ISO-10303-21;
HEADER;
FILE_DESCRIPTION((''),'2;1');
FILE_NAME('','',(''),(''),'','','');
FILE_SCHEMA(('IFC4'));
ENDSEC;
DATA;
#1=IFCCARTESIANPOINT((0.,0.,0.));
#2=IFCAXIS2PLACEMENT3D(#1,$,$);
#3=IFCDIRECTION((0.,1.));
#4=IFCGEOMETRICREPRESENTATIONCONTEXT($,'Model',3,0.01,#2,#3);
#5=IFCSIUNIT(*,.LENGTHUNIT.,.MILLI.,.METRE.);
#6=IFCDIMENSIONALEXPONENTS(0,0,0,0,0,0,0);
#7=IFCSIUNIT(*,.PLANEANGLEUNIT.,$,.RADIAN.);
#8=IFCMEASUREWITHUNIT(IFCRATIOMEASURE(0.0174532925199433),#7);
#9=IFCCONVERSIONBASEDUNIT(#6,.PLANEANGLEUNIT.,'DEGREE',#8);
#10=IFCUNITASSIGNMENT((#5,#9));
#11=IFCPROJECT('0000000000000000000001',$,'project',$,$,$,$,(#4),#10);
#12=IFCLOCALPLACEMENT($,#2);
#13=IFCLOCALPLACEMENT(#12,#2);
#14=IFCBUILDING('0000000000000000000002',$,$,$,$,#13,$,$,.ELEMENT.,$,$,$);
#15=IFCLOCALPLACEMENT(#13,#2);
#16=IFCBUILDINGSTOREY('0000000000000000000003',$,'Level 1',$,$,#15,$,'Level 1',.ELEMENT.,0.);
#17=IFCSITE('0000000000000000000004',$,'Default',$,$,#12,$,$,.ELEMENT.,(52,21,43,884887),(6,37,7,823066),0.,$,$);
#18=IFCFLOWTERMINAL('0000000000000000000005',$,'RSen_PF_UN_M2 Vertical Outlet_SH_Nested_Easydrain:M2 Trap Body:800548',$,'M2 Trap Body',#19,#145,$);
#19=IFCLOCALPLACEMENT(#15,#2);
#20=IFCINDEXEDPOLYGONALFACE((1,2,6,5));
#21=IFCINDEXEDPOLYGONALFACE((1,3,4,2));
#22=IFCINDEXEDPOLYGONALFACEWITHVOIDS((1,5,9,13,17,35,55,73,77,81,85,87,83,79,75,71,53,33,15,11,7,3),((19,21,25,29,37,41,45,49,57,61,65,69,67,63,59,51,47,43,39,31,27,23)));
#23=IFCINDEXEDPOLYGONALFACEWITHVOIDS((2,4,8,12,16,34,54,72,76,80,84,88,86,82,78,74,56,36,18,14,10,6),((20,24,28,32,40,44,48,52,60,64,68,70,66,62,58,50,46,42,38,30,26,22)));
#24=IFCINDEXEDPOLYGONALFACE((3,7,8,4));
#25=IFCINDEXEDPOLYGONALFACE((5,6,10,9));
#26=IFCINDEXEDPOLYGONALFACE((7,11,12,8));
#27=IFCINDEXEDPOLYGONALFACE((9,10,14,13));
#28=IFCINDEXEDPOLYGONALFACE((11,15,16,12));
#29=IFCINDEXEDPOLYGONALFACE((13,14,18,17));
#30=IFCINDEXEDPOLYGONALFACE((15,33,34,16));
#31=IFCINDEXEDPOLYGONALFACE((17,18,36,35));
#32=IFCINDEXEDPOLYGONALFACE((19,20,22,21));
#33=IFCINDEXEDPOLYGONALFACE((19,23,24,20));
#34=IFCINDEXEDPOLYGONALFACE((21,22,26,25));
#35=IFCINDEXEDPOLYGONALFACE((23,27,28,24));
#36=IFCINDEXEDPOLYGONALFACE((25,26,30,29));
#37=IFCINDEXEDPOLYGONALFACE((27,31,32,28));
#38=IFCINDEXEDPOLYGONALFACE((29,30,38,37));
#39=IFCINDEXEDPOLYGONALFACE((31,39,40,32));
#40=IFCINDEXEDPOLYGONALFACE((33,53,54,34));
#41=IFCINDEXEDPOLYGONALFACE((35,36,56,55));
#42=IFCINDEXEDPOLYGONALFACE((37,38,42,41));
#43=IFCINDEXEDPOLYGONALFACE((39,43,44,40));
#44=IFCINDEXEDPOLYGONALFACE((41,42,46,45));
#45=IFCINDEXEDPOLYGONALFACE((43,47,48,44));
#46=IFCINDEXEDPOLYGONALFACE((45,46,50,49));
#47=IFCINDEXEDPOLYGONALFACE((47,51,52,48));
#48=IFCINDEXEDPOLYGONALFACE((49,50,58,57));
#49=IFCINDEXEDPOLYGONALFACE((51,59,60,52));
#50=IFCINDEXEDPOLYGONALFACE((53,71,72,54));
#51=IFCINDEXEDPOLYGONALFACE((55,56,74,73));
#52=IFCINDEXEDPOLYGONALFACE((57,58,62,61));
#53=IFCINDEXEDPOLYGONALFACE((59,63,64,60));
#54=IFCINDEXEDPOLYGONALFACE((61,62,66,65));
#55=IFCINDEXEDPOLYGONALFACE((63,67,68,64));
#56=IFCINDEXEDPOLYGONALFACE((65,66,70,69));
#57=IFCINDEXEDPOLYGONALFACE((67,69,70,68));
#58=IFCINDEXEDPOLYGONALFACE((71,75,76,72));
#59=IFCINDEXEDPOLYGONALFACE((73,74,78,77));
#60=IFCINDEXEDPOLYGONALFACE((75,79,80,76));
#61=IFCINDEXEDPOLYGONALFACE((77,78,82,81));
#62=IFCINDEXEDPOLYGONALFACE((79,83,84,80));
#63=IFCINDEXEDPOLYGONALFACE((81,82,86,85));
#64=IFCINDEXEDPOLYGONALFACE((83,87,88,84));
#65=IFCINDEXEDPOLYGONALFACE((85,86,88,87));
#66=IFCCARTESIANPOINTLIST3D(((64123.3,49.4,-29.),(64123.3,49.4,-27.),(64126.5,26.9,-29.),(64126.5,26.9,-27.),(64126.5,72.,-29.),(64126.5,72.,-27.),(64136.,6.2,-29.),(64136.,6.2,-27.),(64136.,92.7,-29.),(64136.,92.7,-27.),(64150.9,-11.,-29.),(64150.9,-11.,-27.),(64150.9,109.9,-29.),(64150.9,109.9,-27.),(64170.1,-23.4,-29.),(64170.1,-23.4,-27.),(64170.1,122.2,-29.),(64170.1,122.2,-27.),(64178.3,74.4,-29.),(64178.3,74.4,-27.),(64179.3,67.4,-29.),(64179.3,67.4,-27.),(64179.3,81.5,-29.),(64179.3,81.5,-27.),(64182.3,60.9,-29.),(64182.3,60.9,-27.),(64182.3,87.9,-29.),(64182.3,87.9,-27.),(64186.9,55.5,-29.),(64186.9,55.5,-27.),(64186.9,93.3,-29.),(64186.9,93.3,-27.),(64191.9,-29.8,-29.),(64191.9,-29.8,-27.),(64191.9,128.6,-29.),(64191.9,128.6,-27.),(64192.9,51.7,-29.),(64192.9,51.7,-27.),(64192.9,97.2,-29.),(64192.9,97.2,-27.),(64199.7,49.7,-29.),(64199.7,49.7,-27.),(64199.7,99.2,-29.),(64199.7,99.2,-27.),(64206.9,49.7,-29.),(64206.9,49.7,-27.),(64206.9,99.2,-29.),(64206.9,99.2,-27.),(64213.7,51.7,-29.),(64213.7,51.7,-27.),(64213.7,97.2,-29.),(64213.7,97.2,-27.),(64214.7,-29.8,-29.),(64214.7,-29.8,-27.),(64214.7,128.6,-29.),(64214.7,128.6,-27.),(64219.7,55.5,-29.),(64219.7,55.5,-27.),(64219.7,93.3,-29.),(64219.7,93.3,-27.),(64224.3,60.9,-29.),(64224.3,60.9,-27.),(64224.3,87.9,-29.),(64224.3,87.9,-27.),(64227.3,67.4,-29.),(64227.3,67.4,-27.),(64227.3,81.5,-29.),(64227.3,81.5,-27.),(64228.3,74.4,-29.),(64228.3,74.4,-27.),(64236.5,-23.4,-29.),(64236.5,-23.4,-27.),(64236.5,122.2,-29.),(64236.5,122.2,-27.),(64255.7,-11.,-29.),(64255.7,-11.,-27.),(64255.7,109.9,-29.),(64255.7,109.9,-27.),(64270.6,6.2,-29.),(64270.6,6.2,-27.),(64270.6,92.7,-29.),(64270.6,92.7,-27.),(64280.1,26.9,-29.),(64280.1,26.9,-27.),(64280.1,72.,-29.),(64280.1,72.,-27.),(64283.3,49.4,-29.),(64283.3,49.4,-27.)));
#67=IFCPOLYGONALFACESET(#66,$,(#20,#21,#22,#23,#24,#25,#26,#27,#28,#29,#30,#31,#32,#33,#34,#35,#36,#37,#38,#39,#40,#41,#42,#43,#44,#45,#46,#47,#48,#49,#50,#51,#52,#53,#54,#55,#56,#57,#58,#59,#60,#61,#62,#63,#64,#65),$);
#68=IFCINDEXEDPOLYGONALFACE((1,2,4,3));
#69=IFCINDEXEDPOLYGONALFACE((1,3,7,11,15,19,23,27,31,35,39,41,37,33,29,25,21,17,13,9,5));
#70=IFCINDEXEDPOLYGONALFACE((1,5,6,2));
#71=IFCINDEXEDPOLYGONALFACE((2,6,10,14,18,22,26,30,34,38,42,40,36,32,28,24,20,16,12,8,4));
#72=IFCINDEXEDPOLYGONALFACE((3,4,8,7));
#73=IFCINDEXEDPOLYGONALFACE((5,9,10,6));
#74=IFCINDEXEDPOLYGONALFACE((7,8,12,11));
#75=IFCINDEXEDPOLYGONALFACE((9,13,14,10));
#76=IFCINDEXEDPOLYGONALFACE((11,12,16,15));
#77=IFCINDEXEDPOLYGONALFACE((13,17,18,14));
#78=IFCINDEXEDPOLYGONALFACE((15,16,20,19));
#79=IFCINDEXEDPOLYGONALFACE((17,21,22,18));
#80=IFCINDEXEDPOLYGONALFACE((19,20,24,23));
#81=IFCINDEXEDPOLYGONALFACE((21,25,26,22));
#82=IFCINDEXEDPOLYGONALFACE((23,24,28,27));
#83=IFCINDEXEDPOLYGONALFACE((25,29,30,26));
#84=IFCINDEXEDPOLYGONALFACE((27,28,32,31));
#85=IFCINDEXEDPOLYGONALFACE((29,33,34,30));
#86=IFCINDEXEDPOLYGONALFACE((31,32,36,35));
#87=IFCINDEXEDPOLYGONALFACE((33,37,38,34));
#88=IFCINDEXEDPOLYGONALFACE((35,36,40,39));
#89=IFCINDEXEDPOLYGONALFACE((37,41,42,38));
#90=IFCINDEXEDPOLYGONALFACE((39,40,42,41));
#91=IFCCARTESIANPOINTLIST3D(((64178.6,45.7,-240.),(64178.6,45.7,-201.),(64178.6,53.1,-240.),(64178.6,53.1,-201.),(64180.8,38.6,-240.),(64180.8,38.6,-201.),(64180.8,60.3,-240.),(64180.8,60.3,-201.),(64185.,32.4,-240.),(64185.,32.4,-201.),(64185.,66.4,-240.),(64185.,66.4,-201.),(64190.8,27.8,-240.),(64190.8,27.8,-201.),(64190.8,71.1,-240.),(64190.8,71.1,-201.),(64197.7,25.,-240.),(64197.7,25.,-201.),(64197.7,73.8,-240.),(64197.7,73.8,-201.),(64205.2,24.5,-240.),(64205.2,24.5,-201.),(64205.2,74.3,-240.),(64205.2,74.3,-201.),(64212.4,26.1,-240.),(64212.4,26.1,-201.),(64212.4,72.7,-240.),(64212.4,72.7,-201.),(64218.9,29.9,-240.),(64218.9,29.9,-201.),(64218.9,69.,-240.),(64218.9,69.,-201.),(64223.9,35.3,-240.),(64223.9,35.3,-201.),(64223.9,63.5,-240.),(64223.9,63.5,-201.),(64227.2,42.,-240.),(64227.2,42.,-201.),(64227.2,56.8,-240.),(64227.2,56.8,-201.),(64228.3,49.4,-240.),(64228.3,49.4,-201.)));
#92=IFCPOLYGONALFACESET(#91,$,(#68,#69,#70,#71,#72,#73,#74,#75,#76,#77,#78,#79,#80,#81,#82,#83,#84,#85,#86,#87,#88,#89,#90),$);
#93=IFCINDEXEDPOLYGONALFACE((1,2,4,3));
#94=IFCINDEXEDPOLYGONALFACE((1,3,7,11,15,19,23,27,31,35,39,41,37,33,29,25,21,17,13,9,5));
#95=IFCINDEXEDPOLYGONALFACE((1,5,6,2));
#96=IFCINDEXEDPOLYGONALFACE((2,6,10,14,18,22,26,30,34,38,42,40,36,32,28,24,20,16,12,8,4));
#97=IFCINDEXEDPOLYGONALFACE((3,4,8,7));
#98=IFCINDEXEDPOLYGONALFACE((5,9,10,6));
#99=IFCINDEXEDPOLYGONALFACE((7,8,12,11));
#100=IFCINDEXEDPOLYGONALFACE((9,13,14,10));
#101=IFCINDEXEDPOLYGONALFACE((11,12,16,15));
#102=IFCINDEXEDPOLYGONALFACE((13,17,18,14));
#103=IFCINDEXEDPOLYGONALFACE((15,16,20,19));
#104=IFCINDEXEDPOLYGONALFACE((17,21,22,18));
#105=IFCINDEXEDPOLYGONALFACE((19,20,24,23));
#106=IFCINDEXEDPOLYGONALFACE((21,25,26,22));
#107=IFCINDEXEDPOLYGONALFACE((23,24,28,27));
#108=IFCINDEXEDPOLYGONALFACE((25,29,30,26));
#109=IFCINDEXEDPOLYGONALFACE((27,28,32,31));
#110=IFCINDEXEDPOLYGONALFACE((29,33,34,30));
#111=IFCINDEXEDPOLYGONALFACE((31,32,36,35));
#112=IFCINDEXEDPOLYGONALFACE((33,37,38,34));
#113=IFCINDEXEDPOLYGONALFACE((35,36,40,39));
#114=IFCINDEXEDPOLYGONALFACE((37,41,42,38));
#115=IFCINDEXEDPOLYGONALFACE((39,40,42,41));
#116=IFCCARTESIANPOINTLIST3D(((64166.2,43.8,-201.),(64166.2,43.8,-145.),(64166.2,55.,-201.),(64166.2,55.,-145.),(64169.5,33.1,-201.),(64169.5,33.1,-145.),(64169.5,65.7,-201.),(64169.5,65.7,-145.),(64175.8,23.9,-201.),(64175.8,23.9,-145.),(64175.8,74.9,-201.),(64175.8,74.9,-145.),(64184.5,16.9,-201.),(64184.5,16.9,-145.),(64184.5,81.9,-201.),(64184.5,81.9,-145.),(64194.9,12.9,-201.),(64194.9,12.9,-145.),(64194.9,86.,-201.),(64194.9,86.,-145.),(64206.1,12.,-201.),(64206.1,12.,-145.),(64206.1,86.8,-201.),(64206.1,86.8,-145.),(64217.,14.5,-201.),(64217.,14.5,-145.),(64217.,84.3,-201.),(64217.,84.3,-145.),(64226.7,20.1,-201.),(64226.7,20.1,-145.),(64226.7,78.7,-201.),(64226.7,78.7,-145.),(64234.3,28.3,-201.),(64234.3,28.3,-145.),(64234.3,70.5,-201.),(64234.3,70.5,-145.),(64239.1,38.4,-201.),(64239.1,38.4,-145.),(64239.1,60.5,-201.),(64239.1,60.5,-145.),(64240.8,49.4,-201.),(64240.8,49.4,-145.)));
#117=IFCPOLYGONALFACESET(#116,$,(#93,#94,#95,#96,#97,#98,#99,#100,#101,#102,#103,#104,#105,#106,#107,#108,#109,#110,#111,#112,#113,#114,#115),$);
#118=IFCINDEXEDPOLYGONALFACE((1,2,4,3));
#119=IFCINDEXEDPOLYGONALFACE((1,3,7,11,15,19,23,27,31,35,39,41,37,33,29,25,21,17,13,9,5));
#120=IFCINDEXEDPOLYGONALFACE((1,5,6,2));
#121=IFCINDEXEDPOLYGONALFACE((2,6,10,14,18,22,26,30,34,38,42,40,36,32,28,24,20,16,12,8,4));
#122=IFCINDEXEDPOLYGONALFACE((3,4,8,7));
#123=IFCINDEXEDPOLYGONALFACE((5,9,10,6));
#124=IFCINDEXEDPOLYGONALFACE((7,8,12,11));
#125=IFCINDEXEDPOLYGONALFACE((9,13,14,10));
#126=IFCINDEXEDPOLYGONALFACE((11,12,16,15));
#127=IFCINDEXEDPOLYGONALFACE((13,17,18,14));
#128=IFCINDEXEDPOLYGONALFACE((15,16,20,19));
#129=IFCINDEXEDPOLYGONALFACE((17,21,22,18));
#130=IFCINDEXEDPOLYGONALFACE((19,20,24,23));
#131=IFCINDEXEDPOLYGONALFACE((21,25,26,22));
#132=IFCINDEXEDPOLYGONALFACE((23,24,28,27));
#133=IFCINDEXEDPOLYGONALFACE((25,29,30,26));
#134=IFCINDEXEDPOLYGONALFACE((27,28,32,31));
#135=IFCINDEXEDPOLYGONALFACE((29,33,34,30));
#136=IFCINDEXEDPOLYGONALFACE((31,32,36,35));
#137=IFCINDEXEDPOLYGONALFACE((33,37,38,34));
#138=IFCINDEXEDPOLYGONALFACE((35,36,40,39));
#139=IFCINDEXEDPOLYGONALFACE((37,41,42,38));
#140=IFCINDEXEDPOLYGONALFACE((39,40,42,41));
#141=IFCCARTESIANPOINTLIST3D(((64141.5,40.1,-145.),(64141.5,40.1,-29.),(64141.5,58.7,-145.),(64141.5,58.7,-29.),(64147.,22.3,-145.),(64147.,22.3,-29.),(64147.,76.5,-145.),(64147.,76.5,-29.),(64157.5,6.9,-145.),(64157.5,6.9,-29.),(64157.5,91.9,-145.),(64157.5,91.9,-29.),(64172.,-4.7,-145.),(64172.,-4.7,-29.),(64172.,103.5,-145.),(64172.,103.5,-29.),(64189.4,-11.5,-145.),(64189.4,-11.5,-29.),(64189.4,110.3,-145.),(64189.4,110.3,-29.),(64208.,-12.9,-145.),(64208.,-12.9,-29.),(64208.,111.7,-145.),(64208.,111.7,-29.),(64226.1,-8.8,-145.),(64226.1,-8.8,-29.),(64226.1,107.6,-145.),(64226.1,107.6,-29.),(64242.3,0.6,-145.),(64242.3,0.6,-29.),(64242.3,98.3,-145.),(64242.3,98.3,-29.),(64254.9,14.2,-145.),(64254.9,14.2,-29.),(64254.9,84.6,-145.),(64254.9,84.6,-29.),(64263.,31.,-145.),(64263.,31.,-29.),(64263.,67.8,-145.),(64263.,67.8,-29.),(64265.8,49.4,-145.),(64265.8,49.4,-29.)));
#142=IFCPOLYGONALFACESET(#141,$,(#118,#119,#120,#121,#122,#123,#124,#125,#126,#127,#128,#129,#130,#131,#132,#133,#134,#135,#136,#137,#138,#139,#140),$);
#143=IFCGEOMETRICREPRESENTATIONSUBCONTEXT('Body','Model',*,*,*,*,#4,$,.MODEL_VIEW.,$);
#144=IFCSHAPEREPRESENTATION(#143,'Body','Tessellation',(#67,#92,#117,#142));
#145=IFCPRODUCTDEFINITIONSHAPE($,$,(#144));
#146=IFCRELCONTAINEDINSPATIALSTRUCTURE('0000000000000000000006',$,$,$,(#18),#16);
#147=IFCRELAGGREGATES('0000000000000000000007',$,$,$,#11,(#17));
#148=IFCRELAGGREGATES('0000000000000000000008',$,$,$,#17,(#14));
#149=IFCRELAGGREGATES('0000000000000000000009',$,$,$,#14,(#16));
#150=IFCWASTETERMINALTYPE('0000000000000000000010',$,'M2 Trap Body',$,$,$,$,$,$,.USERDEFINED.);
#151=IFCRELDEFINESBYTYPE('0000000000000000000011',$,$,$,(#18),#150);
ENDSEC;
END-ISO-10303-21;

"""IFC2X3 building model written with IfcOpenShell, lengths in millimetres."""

from ifc_helpers import new_model, entity, si_unit, converted_unit, direction, frame, frame_2d, origin, origin_2d_with_axis, place, context, subcontext, project, spatial, circle_curve, parameter, trimmed, segment, composite_curve, circle, outline, extrude, source, transform, mapped, type_object, type_shapes, element, save


model = new_model("IFC2X3")

# Units and contexts
model_context = context("Model", 3, precision=0.01, world=origin(), true_north=direction((0.0, 1.0)))
body_context = subcontext(model_context, "Body", "Model", "MODEL_VIEW")
ifc_project = project(units=[si_unit("LENGTHUNIT", "METRE", prefix="MILLI"), converted_unit("PLANEANGLEUNIT", "DEGREE", entity("IfcRatioMeasure", 0.0174532925199433), si_unit("PLANEANGLEUNIT", "RADIAN"), dimensions=[0, 0, 0, 0, 0, 0, 0])], contexts=[model_context])

# Site, building, storey
site_placement = place(None, origin())
site = spatial("IfcSite", under=ifc_project, at=site_placement, Name="Default", CompositionType="ELEMENT", RefLatitude=(52, 21, 43, 884887), RefLongitude=(6, 37, 7, 823066), RefElevation=0.0)
building_placement = place(site_placement, origin())
building = spatial("IfcBuilding", under=site, at=building_placement, CompositionType="ELEMENT")
storey_placement = place(building_placement, origin())
storey = spatial("IfcBuildingStorey", under=building, at=storey_placement, Name="Level 1", LongName="Level 1", CompositionType="ELEMENT", Elevation=0.0)

# Flow terminal
waste_terminal_type_1 = type_object("IfcWasteTerminalType", Name="M2 Trap Body", PredefinedType="USERDEFINED")
shared_shape_1 = source(origin(), body_context, "Body", "SweptSolid", [
    extrude(outline(composite_curve([segment(trimmed(circle_curve(origin_2d_with_axis(), 80.0), [parameter(0.0)], [parameter(180.0)], True, "PARAMETER"), True, "CONTINUOUS"), segment(trimmed(circle_curve(origin_2d_with_axis(), 80.0), [parameter(180.0)], [parameter(360.0)], True, "PARAMETER"), True, "CONTINUOUS")], self_intersect=False), holes=[composite_curve([segment(trimmed(circle_curve(frame_2d((0.0, 25.0), x_axis=(1.0, 0.0)), 25.0), [parameter(180.0)], [parameter(360.0)], True, "PARAMETER"), False, "CONTINUOUS"), segment(trimmed(circle_curve(frame_2d((0.0, 25.0), x_axis=(1.0, 0.0)), 25.0), [parameter(0.0)], [parameter(180.0)], True, "PARAMETER"), False, "CONTINUOUS")], self_intersect=False)]), frame((0.0, -25.0, -2.0)), (0.0, 0.0, 1.0), 2.0),
    extrude(circle(Radius=25.0, at=frame_2d((0.0, 0.0), x_axis=(1.0, 0.0))), frame((0.0, -25.0, -213.0)), (0.0, 0.0, 1.0), 39.0),
    extrude(circle(Radius=37.5, at=frame_2d((0.0, 0.0), x_axis=(1.0, 0.0))), frame((0.0, -25.0, -174.0)), (0.0, 0.0, 1.0), 56.0),
    extrude(circle(Radius=62.5, at=frame_2d((0.0, 0.0), x_axis=(1.0, 0.0))), frame((0.0, -25.0, -118.0)), (0.0, 0.0, 1.0), 116.0),
])
type_shapes(waste_terminal_type_1, [shared_shape_1])
for number, where, name in (
    (1, (64203.3, 74.4, -27.0), "RSen_PF_UN_M2 Vertical Outlet_SH_Nested_Easydrain:M2 Trap Body:800548"),
):
    element("IfcFlowTerminal", number, at=place(storey_placement, frame(where)), inside=storey, type_object=waste_terminal_type_1, Name=name, ObjectType="M2 Trap Body", context=body_context, shape_type="MappedRepresentation", body=[
        mapped(shared_shape_1, transform((0.0, 0.0, 0.0), scale=1.0)),
    ])

save(model, "model.ifc")
